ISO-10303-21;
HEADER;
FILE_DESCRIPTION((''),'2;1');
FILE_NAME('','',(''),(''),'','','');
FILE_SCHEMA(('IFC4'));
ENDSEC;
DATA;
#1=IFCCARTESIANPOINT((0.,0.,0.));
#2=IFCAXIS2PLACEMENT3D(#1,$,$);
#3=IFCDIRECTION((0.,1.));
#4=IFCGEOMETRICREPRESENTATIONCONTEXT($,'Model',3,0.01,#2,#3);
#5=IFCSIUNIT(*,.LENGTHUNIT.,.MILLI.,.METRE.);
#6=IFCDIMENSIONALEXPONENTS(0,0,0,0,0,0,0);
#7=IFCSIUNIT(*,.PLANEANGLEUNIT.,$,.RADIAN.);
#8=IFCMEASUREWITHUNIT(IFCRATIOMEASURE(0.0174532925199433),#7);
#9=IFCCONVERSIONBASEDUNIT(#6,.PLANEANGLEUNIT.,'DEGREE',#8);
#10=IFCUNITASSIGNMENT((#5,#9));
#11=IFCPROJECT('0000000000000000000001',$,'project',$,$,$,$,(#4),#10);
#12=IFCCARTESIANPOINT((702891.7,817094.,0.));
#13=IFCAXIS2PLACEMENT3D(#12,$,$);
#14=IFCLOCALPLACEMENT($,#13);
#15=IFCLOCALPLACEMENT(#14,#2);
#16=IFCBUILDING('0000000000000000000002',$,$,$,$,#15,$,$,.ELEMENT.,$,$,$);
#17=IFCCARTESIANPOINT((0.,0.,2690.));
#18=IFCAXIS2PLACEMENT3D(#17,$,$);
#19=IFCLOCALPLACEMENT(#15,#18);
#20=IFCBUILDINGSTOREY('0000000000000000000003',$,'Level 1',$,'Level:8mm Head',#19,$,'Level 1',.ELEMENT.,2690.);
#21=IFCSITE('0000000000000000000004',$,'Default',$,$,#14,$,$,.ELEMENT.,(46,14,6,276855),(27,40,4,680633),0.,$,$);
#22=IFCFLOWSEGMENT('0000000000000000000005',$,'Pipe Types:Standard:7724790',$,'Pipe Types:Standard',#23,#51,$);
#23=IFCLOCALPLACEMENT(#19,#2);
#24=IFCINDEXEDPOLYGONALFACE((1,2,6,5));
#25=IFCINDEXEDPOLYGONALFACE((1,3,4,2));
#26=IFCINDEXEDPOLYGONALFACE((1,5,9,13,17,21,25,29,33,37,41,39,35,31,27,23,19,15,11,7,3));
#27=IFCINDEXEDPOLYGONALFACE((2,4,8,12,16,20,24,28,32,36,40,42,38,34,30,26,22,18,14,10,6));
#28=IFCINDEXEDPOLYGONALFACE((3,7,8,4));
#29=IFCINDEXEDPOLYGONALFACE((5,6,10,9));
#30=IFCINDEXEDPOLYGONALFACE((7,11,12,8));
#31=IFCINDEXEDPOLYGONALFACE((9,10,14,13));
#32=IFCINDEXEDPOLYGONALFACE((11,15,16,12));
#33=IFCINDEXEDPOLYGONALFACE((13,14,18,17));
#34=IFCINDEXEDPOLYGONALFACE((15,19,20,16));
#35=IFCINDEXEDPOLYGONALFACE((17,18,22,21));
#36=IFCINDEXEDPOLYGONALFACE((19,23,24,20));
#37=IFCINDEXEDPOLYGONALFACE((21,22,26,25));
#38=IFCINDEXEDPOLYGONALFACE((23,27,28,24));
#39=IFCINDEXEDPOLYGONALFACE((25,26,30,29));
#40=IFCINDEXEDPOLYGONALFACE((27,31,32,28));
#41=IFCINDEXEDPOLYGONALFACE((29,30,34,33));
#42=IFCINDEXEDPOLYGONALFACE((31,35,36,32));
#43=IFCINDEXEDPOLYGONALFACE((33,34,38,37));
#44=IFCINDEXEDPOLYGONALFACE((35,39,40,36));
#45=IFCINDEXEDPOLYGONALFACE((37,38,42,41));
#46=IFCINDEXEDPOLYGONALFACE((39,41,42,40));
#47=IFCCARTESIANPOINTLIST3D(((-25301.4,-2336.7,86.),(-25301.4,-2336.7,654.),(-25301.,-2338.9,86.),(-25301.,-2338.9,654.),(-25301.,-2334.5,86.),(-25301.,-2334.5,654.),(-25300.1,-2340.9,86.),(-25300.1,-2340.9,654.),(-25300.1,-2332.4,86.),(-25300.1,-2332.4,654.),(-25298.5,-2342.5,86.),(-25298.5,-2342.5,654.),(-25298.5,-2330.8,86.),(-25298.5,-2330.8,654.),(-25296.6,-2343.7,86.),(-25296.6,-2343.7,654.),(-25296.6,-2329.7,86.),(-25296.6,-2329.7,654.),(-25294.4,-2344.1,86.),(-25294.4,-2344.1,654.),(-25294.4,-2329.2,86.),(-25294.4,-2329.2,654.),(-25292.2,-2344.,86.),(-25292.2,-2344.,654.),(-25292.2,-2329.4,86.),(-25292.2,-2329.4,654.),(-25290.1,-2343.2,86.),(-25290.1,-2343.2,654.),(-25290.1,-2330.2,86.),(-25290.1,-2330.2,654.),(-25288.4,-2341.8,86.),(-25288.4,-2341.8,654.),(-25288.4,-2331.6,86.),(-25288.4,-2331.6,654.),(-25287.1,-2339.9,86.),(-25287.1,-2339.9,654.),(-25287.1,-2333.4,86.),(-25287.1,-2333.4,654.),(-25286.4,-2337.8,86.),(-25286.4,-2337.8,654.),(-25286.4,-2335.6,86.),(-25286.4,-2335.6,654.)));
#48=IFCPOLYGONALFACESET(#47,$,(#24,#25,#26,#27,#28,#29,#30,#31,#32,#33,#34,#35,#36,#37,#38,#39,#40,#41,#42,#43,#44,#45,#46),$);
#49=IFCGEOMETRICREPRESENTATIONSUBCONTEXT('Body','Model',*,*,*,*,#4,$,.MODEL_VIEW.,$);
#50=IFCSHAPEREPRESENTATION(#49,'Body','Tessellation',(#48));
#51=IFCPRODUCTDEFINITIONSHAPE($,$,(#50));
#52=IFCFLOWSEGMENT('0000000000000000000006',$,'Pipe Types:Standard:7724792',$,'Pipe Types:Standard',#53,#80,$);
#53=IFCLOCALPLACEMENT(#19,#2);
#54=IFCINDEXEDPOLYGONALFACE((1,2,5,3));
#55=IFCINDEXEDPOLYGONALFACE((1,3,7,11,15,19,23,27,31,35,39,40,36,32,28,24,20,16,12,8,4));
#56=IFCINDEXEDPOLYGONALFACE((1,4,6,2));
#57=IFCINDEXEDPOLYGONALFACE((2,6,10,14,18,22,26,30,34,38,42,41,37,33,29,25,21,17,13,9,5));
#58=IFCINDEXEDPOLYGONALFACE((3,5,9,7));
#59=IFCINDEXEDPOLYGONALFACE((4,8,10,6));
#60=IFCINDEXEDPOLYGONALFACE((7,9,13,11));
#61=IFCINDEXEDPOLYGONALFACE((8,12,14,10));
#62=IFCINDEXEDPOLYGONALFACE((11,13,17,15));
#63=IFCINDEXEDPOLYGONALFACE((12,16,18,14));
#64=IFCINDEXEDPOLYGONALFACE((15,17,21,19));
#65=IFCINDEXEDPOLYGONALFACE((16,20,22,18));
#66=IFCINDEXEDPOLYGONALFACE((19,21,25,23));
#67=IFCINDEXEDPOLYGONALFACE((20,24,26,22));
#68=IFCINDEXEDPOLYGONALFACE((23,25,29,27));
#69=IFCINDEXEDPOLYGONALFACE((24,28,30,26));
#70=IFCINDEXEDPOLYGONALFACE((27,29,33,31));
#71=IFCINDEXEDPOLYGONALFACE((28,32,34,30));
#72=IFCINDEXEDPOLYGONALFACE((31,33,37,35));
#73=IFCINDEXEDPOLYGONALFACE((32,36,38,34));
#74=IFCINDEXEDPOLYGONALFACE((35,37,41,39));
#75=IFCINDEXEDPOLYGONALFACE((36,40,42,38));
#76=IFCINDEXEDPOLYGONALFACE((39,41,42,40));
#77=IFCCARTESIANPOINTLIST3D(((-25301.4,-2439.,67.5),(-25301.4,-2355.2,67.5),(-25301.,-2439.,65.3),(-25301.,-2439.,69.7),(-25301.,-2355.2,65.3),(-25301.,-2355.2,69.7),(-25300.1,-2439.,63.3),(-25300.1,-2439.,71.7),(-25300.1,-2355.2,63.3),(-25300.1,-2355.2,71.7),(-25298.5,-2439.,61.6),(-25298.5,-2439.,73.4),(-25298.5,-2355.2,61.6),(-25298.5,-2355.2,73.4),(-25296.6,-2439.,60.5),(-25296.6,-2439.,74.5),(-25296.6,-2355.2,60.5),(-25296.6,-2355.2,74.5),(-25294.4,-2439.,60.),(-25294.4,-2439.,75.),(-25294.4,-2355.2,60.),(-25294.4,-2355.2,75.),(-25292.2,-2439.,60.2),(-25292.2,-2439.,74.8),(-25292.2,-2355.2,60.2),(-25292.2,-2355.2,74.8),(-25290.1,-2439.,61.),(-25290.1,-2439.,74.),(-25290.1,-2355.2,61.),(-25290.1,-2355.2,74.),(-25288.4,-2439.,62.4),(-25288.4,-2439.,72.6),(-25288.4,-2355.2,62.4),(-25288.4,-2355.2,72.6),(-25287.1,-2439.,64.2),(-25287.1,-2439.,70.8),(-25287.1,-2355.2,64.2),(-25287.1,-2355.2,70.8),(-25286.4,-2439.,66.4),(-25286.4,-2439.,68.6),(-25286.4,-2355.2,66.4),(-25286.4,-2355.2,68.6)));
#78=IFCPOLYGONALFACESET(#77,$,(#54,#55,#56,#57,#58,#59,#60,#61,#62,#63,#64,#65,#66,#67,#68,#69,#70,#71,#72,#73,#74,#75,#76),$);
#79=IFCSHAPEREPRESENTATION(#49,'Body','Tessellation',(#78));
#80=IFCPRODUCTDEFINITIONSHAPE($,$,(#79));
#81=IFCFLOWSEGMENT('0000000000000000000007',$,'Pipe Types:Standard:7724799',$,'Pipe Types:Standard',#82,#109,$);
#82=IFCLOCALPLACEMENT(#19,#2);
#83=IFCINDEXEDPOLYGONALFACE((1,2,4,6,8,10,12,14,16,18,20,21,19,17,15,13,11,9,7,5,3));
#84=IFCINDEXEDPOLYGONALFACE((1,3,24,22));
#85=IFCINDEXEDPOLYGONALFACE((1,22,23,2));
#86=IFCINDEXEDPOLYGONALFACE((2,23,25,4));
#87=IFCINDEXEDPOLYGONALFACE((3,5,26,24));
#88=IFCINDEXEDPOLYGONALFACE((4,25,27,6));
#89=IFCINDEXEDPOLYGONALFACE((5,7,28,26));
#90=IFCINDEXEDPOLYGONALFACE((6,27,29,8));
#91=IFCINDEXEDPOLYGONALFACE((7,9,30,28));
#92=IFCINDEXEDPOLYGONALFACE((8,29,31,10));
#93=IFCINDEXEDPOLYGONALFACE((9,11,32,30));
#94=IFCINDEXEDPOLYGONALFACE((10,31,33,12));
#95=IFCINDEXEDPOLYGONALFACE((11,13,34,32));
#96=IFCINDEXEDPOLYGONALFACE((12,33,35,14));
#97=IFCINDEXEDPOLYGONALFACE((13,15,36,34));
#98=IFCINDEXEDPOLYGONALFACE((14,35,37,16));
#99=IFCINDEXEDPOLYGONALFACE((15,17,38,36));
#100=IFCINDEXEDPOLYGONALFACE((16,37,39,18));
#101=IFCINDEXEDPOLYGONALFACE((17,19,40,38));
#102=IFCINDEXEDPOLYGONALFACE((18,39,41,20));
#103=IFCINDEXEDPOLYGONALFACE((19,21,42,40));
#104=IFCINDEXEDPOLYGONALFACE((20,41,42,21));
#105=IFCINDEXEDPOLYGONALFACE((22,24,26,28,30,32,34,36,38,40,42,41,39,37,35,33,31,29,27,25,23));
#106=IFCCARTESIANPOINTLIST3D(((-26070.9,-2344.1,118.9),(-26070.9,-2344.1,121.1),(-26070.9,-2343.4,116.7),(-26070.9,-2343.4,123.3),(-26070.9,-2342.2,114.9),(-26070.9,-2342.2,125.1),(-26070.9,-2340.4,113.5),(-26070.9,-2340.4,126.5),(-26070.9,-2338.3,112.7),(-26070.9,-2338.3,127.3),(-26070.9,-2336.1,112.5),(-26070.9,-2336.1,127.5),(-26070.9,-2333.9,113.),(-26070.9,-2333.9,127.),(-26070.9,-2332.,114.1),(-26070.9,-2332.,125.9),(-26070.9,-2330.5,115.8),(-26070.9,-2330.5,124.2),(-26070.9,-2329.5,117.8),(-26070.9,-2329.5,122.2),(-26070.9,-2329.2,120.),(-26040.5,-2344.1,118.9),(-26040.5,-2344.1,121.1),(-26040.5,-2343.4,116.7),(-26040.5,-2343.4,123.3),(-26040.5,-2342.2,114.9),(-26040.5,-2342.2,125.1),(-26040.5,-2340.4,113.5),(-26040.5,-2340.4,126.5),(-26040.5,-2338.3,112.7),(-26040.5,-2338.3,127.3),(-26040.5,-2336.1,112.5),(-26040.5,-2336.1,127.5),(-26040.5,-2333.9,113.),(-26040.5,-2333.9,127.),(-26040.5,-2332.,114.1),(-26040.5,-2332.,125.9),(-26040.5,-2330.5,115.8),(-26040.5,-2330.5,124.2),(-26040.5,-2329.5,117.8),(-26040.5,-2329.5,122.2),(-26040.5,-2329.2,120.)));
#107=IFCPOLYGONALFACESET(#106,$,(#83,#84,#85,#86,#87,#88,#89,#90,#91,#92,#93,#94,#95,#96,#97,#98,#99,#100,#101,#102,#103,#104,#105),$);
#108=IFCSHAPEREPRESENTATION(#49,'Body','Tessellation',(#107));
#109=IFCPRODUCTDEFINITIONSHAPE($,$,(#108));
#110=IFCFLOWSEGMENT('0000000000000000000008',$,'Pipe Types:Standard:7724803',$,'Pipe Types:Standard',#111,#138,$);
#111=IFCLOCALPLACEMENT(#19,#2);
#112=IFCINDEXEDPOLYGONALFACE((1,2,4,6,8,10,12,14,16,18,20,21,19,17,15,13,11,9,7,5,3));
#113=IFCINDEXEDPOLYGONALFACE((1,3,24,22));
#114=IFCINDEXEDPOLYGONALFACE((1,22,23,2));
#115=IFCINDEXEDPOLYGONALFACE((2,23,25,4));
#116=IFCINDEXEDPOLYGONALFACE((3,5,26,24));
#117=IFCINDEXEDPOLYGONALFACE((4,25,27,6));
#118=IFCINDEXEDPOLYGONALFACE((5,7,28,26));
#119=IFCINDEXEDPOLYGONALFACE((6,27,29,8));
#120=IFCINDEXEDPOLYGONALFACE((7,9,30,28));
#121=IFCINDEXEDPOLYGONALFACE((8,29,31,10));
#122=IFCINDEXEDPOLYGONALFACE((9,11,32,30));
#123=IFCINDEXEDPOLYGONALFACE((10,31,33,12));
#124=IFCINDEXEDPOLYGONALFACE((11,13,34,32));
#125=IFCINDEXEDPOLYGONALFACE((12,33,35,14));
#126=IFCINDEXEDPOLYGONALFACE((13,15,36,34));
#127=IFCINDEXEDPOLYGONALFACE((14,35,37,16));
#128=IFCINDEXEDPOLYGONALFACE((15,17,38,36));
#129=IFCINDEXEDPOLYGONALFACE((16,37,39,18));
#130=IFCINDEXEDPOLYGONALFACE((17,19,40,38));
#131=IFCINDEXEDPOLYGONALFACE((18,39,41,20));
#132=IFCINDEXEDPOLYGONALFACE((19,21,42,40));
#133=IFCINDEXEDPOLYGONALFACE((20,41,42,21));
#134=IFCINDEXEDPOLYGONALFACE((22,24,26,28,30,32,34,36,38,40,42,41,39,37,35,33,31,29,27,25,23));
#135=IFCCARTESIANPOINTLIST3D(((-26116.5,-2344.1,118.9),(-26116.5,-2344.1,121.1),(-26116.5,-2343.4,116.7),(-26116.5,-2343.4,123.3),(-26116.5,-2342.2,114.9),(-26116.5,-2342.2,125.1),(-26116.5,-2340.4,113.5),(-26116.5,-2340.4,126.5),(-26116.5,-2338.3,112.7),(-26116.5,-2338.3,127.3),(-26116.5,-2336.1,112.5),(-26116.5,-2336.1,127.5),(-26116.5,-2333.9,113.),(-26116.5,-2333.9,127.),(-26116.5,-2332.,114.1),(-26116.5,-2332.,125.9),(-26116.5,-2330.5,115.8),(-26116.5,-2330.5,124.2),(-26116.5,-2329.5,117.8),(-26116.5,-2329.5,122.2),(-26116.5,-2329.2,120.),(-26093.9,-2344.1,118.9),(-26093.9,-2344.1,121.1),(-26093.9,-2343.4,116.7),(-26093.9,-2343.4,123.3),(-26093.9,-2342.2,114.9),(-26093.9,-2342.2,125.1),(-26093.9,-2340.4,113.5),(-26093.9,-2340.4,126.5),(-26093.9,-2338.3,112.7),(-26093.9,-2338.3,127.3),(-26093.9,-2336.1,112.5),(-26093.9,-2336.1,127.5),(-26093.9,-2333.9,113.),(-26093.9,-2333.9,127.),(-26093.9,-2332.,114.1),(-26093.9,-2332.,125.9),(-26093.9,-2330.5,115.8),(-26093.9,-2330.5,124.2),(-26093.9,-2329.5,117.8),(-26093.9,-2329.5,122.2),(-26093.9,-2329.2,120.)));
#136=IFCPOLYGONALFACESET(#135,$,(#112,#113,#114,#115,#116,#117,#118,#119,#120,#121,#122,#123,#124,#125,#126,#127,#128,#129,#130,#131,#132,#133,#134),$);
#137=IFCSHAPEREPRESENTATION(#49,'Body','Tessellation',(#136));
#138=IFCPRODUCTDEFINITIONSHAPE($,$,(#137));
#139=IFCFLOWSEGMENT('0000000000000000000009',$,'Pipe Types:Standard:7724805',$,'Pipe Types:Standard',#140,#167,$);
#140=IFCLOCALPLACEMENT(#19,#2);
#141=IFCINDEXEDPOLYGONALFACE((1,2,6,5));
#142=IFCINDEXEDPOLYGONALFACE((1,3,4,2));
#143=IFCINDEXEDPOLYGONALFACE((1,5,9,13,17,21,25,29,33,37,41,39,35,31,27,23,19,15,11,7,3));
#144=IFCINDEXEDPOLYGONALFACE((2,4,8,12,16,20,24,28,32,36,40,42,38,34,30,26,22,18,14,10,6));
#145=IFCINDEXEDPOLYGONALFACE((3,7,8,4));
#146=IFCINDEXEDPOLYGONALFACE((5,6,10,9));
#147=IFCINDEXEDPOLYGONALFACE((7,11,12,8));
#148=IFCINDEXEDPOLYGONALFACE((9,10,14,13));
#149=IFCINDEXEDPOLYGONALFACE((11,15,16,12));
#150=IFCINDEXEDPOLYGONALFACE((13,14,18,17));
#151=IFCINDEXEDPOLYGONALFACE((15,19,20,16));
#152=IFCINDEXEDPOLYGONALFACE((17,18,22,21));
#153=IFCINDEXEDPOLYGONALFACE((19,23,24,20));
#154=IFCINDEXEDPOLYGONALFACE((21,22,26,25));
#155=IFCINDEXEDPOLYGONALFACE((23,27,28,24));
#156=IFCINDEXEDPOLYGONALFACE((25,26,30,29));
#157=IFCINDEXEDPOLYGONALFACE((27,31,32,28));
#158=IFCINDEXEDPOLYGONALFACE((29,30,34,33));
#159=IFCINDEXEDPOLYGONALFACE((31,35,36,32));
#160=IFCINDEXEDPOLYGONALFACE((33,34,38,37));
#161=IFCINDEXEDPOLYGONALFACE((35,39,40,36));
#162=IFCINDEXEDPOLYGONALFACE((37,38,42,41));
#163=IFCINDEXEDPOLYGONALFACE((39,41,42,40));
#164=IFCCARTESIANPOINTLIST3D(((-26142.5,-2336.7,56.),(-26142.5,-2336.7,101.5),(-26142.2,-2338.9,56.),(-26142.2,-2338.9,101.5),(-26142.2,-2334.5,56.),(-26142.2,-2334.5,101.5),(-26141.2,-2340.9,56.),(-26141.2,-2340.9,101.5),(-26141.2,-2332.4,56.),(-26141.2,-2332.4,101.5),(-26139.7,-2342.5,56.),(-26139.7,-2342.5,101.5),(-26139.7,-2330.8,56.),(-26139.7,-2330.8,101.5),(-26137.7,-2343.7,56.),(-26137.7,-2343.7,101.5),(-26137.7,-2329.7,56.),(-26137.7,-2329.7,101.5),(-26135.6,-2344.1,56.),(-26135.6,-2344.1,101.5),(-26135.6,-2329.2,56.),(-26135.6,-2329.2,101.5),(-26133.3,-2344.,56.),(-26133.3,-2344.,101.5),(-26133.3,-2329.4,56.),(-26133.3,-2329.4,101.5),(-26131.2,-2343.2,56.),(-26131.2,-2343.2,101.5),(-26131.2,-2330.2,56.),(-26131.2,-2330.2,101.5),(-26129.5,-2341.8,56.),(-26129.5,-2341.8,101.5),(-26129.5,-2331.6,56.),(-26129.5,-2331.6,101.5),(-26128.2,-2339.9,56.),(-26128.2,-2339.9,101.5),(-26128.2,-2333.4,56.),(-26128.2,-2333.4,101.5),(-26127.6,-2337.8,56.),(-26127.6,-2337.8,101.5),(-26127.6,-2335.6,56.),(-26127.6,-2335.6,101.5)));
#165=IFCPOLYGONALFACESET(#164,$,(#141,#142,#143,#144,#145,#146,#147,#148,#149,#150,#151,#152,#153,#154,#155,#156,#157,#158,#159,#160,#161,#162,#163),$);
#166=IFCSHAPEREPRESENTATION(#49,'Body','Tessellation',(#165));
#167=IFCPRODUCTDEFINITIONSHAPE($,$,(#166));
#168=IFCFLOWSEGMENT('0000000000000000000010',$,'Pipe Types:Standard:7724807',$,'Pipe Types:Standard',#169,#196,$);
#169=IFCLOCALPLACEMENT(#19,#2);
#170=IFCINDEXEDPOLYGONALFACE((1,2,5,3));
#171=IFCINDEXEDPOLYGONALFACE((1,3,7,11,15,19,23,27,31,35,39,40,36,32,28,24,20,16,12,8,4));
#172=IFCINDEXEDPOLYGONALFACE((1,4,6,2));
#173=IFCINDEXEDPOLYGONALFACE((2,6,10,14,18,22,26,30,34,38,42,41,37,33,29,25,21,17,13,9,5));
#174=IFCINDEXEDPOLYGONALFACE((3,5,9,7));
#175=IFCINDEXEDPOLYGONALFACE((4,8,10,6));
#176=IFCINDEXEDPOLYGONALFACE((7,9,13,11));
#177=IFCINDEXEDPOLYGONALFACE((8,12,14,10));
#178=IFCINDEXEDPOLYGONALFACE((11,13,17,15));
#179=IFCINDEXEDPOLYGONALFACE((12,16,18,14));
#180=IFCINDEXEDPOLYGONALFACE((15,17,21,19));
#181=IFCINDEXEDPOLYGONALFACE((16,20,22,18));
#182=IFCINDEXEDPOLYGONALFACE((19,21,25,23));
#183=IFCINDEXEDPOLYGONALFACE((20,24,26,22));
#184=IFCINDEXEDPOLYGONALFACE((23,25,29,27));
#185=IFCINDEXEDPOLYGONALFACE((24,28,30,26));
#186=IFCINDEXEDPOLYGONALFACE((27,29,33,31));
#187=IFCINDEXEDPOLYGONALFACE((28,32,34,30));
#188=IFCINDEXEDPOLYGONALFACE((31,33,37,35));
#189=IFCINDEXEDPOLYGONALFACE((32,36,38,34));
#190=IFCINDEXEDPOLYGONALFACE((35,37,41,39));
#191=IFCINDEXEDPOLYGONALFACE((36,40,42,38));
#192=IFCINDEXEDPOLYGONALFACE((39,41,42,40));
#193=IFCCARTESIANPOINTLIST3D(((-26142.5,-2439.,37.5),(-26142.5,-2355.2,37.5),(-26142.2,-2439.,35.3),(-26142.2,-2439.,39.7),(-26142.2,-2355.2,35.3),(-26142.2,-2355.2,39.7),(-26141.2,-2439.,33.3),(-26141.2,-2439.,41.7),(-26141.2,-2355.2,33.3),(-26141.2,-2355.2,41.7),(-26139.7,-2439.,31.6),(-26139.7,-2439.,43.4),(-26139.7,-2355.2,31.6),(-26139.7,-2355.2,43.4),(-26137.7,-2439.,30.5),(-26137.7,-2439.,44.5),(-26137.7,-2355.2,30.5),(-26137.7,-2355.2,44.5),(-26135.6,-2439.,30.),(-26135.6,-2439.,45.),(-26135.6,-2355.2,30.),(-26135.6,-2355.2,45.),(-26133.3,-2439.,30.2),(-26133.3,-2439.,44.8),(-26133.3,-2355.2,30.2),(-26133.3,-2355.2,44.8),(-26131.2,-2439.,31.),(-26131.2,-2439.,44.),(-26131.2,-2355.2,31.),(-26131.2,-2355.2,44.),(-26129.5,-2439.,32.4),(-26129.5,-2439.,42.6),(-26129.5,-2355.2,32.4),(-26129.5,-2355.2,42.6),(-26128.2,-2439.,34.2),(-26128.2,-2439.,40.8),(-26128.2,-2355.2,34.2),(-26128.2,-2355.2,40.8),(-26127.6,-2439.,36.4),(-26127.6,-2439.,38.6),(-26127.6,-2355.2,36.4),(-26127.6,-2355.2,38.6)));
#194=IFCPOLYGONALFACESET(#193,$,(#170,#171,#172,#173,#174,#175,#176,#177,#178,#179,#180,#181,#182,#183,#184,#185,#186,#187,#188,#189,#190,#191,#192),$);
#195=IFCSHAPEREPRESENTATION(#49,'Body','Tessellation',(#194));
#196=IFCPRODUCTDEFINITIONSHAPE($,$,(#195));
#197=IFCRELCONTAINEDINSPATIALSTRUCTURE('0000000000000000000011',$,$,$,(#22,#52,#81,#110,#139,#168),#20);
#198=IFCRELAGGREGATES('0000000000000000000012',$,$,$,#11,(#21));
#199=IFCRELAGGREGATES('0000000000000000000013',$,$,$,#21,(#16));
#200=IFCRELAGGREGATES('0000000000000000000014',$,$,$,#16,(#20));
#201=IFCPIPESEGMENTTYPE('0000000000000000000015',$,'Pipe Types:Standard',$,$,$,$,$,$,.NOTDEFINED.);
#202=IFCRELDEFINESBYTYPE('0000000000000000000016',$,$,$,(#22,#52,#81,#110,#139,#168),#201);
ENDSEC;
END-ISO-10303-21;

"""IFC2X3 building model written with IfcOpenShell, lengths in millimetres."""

from ifc_helpers import new_model, entity, si_unit, converted_unit, direction, frame, frame_2d, origin, origin_2d_with_axis, place, context, subcontext, project, spatial, circle, extrude, type_object, element, save


model = new_model("IFC2X3")

# Units and contexts
model_context = context("Model", 3, precision=0.01, world=origin(), true_north=direction((0.0, 1.0)))
body_context = subcontext(model_context, "Body", "Model", "MODEL_VIEW")
ifc_project = project(units=[si_unit("LENGTHUNIT", "METRE", prefix="MILLI"), converted_unit("PLANEANGLEUNIT", "DEGREE", entity("IfcRatioMeasure", 0.0174532925199433), si_unit("PLANEANGLEUNIT", "RADIAN"), dimensions=[0, 0, 0, 0, 0, 0, 0])], contexts=[model_context])

# Site, building, storey
site_placement = place(None, frame((702891.7, 817094.0, 0.0)))
site = spatial("IfcSite", under=ifc_project, at=site_placement, Name="Default", CompositionType="ELEMENT", RefLatitude=(46, 14, 6, 276855), RefLongitude=(27, 40, 4, 680633), RefElevation=0.0)
building_placement = place(site_placement, origin())
building = spatial("IfcBuilding", under=site, at=building_placement, CompositionType="ELEMENT")
storey_placement = place(building_placement, frame((0.0, 0.0, 2690.0)))
storey = spatial("IfcBuildingStorey", under=building, at=storey_placement, Name="Level 1", ObjectType="Level:8mm Head", LongName="Level 1", CompositionType="ELEMENT", Elevation=2690.0)

# Flow segments
pipe_segment_type = type_object("IfcPipeSegmentType", Name="Pipe Types:Standard", PredefinedType="NOTDEFINED")
flow_segment_1_placement = place(storey_placement, origin())
element("IfcFlowSegment", 1, at=flow_segment_1_placement, inside=storey, type_object=pipe_segment_type, Name="Pipe Types:Standard:7724790", ObjectType="Pipe Types:Standard", context=body_context, shape_type="SweptSolid", body=[
    extrude(circle(Radius=7.5, at=origin_2d_with_axis()), frame((-25293.9, -2336.7, 86.0), z_axis=(0.0, 0.0, 1.0), x_axis=(-1.0, 0.0, 0.0)), (0.0, 0.0, 1.0), 568.0),
])
flow_segment_2_placement = place(storey_placement, origin())
element("IfcFlowSegment", 2, at=flow_segment_2_placement, inside=storey, type_object=pipe_segment_type, Name="Pipe Types:Standard:7724792", ObjectType="Pipe Types:Standard", context=body_context, shape_type="SweptSolid", body=[
    extrude(circle(Radius=7.5, at=frame_2d((0.0, 0.0), x_axis=(1.0, 0.0))), frame((-25293.9, -2439.0, 67.5), z_axis=(0.0, 1.0, 0.0), x_axis=(-1.0, 0.0, 0.0)), (0.0, 0.0, 1.0), 83.8),
])
flow_segment_3_placement = place(storey_placement, origin())
element("IfcFlowSegment", 3, at=flow_segment_3_placement, inside=storey, type_object=pipe_segment_type, Name="Pipe Types:Standard:7724799", ObjectType="Pipe Types:Standard", context=body_context, shape_type="SweptSolid", body=[
    extrude(circle(Radius=7.5, at=frame_2d((0.0, 0.0), x_axis=(1.0, 0.0))), frame((-26070.9, -2336.7, 120.0), z_axis=(1.0, 0.0, 0.0), x_axis=(0.0, 1.0, 0.0)), (0.0, 0.0, 1.0), 30.4),
])
flow_segment_4_placement = place(storey_placement, origin())
element("IfcFlowSegment", 4, at=flow_segment_4_placement, inside=storey, type_object=pipe_segment_type, Name="Pipe Types:Standard:7724803", ObjectType="Pipe Types:Standard", context=body_context, shape_type="SweptSolid", body=[
    extrude(circle(Radius=7.5, at=frame_2d((0.0, 0.0), x_axis=(1.0, 0.0))), frame((-26116.5, -2336.7, 120.0), z_axis=(1.0, 0.0, 0.0), x_axis=(0.0, 1.0, 0.0)), (0.0, 0.0, 1.0), 22.6),
])
flow_segment_5_placement = place(storey_placement, origin())
element("IfcFlowSegment", 5, at=flow_segment_5_placement, inside=storey, type_object=pipe_segment_type, Name="Pipe Types:Standard:7724805", ObjectType="Pipe Types:Standard", context=body_context, shape_type="SweptSolid", body=[
    extrude(circle(Radius=7.5, at=origin_2d_with_axis()), frame((-26135.0, -2336.7, 56.0), z_axis=(0.0, 0.0, 1.0), x_axis=(-1.0, 0.0, 0.0)), (0.0, 0.0, 1.0), 45.5),
])
flow_segment_6_placement = place(storey_placement, origin())
element("IfcFlowSegment", 6, at=flow_segment_6_placement, inside=storey, type_object=pipe_segment_type, Name="Pipe Types:Standard:7724807", ObjectType="Pipe Types:Standard", context=body_context, shape_type="SweptSolid", body=[
    extrude(circle(Radius=7.5, at=frame_2d((0.0, 0.0), x_axis=(1.0, 0.0))), frame((-26135.0, -2439.0, 37.5), z_axis=(0.0, 1.0, 0.0), x_axis=(-1.0, 0.0, 0.0)), (0.0, 0.0, 1.0), 83.8),
])

save(model, "model.ifc")
